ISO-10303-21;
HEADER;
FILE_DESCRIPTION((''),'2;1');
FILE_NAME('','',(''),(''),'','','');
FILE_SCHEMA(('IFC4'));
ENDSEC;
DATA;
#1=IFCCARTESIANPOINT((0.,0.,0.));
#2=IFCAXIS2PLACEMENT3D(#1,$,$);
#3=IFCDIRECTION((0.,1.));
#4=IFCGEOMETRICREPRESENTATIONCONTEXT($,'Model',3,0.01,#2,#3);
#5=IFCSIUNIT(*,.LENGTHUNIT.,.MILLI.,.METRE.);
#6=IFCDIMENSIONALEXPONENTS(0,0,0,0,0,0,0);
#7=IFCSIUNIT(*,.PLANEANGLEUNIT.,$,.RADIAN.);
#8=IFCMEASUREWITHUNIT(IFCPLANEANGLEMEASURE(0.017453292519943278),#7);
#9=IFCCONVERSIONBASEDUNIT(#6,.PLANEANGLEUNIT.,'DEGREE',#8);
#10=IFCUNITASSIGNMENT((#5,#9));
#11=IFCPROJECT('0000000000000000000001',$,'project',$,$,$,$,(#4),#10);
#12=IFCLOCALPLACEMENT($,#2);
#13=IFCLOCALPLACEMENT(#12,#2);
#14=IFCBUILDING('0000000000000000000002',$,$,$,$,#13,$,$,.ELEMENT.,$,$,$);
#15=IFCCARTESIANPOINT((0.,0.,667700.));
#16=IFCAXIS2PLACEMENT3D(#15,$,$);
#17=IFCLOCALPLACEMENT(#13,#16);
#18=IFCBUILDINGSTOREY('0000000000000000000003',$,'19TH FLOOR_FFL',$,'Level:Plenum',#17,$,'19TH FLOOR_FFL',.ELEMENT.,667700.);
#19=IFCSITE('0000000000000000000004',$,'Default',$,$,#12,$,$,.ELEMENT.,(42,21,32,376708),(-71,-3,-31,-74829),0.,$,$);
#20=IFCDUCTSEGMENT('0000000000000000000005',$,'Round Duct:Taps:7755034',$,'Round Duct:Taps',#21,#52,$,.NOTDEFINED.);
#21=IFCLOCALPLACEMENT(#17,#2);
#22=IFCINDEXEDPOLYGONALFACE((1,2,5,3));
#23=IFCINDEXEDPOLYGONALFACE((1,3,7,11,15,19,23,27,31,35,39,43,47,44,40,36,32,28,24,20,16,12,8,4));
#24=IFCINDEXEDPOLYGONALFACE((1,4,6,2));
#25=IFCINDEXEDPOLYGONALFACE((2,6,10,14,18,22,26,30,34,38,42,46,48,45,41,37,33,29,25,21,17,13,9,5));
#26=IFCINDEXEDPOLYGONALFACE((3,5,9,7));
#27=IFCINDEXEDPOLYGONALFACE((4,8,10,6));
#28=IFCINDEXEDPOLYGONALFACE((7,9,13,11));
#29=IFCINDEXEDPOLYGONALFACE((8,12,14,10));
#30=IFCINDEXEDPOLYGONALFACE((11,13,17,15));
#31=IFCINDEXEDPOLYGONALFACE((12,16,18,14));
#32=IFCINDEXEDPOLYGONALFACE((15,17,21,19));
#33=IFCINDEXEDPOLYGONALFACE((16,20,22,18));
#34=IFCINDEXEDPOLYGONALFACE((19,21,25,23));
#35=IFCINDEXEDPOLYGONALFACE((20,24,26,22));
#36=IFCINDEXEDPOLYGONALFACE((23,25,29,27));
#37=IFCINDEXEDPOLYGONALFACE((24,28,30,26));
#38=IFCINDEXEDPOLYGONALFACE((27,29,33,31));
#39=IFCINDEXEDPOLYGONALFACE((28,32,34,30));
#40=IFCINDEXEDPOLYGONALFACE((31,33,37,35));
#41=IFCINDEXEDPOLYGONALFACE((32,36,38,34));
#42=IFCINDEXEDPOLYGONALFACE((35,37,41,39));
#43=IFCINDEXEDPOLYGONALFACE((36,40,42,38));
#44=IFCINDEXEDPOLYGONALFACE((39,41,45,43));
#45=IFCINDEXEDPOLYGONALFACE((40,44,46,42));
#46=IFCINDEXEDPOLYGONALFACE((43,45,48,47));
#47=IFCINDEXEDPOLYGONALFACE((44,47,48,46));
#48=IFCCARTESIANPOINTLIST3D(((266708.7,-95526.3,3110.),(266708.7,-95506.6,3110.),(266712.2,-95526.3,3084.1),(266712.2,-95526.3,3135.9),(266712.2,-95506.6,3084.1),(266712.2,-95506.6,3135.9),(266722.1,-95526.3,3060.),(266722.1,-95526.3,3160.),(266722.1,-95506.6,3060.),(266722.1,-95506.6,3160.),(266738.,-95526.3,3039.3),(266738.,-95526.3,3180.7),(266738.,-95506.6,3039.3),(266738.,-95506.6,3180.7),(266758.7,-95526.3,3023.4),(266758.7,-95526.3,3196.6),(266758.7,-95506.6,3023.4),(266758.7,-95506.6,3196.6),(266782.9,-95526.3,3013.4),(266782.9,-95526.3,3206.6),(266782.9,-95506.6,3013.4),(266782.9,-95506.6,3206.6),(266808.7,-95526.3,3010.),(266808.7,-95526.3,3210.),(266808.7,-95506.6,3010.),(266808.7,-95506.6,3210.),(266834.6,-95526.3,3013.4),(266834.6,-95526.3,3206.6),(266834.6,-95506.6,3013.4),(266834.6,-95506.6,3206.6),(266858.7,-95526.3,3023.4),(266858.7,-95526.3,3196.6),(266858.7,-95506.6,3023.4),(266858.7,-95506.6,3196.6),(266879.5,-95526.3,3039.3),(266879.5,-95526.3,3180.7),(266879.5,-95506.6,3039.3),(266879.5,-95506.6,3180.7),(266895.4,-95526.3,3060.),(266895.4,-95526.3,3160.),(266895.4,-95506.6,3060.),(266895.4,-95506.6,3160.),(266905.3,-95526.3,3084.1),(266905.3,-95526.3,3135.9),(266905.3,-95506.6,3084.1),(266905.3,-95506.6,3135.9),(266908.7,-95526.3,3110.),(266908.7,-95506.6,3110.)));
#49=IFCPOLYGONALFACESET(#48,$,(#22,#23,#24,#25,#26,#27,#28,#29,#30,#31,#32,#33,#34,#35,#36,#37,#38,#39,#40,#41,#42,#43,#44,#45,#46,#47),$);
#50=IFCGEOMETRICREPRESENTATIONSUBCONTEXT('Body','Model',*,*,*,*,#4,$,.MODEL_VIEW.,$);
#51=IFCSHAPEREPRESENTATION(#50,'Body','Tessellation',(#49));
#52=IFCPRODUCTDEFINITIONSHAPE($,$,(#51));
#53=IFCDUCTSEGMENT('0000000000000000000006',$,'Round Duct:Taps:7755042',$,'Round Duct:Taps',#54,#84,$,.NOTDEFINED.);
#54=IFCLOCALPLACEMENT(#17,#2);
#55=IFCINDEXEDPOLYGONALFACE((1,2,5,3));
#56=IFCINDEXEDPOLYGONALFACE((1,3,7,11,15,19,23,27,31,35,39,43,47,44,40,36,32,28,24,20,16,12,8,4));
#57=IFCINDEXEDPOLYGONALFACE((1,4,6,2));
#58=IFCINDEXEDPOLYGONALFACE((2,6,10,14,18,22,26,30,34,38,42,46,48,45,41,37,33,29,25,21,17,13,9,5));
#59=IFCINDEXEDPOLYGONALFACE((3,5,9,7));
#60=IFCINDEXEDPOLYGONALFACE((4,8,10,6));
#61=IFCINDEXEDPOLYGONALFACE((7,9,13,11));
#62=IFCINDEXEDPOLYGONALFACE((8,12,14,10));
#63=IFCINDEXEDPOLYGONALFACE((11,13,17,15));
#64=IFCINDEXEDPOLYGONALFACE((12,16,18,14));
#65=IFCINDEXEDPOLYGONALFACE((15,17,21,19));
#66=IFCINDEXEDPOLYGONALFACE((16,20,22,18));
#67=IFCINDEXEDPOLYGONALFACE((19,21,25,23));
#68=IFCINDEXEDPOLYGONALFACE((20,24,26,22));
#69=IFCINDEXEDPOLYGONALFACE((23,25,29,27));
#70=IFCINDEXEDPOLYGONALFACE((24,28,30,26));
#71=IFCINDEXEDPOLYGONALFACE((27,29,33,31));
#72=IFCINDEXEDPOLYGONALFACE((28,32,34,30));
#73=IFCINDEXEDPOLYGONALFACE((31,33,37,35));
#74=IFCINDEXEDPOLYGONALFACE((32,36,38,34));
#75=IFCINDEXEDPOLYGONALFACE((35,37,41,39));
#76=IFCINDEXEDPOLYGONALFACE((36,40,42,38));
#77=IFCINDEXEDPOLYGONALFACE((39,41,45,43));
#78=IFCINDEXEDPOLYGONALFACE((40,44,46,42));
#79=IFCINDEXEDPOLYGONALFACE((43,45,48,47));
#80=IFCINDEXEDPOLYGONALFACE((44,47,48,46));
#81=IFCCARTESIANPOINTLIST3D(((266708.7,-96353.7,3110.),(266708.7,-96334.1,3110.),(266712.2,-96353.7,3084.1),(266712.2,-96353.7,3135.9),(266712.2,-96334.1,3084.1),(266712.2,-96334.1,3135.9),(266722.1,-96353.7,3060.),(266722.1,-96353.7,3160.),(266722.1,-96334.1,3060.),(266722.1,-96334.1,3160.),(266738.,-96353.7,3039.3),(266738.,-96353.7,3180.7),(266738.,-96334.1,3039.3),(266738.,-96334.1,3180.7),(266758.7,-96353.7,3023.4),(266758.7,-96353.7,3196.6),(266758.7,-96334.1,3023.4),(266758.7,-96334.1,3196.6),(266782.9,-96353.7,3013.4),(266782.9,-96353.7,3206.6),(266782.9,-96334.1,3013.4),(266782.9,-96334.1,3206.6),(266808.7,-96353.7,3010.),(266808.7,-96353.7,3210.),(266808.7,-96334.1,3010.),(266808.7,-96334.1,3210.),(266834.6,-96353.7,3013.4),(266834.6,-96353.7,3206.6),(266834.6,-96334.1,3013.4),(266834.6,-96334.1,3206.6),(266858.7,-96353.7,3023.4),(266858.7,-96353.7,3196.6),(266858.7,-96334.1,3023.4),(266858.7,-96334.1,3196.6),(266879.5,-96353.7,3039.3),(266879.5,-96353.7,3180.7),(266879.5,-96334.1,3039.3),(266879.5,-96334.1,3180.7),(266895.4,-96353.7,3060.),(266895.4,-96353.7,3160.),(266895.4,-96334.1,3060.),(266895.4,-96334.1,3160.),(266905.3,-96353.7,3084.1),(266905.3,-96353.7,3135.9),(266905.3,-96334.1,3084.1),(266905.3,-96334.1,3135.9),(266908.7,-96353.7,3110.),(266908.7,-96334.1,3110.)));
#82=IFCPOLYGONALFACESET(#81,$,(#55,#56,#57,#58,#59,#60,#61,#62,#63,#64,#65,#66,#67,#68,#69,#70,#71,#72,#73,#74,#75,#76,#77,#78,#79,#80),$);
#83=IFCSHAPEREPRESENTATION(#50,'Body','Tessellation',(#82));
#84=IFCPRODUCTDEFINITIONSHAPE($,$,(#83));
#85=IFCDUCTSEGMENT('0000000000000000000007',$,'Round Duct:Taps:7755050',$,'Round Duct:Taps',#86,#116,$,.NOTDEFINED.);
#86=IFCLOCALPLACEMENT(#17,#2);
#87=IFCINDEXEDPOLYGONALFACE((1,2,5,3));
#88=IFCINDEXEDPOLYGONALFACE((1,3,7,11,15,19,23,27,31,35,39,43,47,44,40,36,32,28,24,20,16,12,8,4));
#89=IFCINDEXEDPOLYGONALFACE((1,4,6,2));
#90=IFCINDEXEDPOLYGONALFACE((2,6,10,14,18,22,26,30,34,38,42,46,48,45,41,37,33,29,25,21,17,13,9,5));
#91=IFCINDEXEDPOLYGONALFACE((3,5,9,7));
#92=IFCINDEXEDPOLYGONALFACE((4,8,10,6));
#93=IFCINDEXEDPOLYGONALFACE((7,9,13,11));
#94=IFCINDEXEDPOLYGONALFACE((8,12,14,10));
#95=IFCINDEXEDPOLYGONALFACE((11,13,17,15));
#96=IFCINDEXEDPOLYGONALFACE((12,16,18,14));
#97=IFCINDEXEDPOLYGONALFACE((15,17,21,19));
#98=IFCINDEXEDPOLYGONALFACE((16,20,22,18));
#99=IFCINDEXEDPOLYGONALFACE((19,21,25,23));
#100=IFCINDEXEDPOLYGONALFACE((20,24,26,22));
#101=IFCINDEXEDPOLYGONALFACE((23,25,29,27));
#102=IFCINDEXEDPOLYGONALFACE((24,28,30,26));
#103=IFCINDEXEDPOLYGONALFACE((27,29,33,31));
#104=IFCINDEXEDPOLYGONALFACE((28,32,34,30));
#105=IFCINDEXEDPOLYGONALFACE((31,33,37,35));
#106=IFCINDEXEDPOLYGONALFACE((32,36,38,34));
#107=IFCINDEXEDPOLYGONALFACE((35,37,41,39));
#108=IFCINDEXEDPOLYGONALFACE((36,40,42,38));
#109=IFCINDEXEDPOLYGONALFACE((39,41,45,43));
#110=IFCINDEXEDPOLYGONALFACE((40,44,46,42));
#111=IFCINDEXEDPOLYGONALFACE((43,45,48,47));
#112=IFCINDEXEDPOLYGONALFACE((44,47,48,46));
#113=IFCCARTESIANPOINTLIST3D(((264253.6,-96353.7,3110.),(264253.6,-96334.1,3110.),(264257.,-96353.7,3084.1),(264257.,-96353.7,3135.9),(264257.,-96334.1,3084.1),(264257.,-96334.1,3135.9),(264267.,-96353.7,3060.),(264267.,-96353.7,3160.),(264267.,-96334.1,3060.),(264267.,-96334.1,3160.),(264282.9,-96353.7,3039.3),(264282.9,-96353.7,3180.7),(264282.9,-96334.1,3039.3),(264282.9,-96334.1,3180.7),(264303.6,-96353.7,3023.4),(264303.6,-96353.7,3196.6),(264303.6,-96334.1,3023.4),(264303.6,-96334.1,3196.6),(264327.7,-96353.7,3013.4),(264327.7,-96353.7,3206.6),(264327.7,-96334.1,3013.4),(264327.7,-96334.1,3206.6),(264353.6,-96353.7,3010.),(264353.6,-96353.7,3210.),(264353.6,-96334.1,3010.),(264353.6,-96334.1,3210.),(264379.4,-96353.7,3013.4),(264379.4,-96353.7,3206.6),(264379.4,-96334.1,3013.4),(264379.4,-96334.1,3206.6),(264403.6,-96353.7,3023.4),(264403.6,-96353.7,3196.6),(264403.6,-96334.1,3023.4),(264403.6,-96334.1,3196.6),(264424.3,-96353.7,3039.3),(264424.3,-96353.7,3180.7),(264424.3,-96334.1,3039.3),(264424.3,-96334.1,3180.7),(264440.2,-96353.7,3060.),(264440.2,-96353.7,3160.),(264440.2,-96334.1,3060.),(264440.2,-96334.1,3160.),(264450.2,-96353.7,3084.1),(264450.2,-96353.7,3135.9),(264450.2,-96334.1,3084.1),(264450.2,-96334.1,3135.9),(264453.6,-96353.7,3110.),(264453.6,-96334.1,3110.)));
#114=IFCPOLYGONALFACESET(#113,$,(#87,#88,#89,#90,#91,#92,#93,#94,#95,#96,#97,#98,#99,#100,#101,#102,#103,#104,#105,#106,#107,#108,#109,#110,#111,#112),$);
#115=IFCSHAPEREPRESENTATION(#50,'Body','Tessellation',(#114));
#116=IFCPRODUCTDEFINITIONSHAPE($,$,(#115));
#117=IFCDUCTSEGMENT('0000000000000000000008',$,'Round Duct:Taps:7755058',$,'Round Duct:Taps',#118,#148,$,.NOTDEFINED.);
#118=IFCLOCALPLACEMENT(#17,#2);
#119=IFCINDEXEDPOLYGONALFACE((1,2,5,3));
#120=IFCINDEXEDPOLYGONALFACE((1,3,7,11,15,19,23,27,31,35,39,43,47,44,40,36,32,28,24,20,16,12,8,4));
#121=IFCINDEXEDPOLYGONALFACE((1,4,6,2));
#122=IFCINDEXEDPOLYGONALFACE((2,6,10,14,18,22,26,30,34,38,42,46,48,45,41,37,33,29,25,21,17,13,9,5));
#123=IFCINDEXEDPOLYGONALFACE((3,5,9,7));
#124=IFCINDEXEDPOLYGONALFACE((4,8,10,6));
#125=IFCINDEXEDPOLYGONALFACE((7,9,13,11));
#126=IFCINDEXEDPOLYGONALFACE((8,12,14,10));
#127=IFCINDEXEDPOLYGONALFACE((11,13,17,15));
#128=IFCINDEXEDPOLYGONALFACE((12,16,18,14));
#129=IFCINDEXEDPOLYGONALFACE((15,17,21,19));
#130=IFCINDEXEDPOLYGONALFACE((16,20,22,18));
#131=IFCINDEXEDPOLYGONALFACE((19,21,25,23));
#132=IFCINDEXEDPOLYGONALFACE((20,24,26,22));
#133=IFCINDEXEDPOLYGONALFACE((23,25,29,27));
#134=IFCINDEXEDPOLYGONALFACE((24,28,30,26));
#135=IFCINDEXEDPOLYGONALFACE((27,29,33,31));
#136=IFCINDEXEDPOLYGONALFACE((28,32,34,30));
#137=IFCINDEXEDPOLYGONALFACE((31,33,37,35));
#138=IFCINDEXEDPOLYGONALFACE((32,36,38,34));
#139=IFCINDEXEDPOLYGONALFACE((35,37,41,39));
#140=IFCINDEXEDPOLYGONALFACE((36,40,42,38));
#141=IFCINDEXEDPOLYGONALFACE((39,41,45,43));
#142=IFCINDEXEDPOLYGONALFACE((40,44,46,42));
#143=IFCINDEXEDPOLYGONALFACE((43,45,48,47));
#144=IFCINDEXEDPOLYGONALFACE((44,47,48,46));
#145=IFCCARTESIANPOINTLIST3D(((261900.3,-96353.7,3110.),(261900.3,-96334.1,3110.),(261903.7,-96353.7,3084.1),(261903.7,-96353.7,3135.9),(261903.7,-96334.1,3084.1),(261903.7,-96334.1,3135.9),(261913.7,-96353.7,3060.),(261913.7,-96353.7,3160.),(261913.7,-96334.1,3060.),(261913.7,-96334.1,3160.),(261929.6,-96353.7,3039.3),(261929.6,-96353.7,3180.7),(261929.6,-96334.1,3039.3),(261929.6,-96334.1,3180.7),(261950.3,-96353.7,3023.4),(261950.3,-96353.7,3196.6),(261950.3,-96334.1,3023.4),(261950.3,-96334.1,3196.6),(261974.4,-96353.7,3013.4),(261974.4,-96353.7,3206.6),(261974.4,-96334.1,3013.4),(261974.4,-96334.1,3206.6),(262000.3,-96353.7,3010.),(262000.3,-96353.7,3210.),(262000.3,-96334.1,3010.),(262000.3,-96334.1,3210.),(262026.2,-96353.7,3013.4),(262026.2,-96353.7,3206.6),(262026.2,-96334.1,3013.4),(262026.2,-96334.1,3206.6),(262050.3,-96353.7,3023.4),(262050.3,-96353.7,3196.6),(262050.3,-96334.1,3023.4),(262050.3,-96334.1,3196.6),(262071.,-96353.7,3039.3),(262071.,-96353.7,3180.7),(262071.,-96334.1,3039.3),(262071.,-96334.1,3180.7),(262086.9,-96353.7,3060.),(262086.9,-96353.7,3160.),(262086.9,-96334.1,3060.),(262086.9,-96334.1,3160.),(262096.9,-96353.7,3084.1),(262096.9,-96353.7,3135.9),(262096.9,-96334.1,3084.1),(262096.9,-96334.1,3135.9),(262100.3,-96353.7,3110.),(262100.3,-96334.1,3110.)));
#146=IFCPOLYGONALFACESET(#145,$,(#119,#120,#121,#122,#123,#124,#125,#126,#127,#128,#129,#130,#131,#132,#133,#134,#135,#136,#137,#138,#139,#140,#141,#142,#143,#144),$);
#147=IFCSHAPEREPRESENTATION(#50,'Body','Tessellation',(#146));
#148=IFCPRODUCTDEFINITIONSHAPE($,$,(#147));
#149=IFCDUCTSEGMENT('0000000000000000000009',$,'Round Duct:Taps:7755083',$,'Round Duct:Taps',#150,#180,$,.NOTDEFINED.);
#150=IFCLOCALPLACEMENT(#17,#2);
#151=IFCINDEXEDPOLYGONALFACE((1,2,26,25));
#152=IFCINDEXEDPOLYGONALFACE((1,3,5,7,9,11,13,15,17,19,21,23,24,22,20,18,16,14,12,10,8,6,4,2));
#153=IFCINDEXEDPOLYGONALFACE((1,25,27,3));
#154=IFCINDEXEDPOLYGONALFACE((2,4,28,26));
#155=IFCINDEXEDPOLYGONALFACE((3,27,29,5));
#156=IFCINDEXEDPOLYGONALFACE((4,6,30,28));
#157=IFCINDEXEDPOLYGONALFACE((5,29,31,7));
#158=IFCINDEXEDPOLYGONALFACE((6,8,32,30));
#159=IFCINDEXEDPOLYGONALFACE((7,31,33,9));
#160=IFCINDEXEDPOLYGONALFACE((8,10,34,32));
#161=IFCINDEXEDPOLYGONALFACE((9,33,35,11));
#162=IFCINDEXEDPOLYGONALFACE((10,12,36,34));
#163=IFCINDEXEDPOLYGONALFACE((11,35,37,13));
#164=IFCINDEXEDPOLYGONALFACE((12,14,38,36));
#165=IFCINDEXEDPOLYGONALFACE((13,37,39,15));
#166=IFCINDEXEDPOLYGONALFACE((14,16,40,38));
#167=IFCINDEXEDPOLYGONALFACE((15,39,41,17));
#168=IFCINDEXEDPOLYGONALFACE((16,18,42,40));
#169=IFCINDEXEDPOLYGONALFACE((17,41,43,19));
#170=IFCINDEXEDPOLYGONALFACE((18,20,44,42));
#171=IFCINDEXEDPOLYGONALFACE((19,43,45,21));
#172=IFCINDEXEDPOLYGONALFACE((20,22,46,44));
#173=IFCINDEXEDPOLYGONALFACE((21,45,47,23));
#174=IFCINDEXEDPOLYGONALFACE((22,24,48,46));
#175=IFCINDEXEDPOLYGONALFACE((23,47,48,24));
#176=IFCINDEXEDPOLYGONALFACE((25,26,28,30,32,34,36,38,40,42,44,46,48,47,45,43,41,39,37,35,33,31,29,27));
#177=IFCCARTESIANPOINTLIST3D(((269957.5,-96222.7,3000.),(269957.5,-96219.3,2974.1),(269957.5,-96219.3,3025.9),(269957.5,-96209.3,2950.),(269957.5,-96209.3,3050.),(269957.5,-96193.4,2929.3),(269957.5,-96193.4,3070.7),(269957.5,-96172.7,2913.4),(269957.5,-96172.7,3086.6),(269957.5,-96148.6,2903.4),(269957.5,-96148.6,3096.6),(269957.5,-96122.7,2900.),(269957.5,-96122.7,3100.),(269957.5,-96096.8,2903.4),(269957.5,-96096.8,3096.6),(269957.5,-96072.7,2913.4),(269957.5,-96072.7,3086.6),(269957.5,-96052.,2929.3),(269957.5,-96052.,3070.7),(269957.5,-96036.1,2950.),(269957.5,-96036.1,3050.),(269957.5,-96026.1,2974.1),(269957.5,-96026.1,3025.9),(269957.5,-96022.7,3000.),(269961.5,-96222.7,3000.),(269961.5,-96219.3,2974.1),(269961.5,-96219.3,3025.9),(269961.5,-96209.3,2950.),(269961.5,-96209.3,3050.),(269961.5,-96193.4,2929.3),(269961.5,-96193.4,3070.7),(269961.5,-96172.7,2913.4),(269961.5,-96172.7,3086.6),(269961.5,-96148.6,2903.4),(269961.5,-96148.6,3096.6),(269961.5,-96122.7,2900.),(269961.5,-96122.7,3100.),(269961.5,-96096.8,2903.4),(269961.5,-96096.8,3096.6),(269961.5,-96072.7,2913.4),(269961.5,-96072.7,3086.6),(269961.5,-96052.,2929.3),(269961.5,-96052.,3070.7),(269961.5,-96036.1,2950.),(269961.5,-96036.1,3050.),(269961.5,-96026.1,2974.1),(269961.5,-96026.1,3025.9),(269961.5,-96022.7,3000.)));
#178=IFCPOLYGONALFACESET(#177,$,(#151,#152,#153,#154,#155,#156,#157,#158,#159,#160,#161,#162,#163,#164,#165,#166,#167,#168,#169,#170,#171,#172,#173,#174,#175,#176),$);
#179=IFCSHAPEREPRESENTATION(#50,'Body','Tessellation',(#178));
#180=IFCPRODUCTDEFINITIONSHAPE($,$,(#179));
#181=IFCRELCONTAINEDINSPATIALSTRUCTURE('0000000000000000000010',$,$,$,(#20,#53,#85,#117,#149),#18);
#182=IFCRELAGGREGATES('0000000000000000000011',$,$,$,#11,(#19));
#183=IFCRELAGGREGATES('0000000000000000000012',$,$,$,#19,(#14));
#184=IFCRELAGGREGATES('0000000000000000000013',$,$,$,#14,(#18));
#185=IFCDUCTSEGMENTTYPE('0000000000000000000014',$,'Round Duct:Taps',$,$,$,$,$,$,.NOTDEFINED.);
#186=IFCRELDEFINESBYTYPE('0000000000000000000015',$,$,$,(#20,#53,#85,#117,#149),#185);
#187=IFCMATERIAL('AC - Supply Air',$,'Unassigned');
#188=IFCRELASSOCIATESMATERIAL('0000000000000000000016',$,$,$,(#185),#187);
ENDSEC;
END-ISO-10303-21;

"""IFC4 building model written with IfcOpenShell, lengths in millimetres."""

from ifc_helpers import new_model, entity, si_unit, converted_unit, direction, frame, origin, place, context, subcontext, project, spatial, arc, indexed_curve, outline, extrude, material, type_object, element, save


model = new_model("IFC4")

# Units and contexts
model_context = context("Model", 3, precision=0.01, world=origin(), true_north=direction((0.0, 1.0)))
body_context = subcontext(model_context, "Body", "Model", "MODEL_VIEW")
ifc_project = project(units=[si_unit("LENGTHUNIT", "METRE", prefix="MILLI"), converted_unit("PLANEANGLEUNIT", "DEGREE", entity("IfcPlaneAngleMeasure", 0.017453292519943278), si_unit("PLANEANGLEUNIT", "RADIAN"), dimensions=[0, 0, 0, 0, 0, 0, 0])], contexts=[model_context])

# Site, building, storey
site_placement = place(None, origin())
site = spatial("IfcSite", under=ifc_project, at=site_placement, Name="Default", CompositionType="ELEMENT", RefLatitude=(42, 21, 32, 376708), RefLongitude=(-71, -3, -31, -74829), RefElevation=0.0)
building_placement = place(site_placement, origin())
building = spatial("IfcBuilding", under=site, at=building_placement, CompositionType="ELEMENT")
storey_placement = place(building_placement, frame((0.0, 0.0, 667700.0)))
storey = spatial("IfcBuildingStorey", under=building, at=storey_placement, Name="19TH FLOOR_FFL", ObjectType="Level:Plenum", LongName="19TH FLOOR_FFL", CompositionType="ELEMENT", Elevation=667700.0)

# Duct segments
ifc_material_1 = material(Name="AC - Supply Air", Category="Unassigned")
duct_segment_type_1 = type_object("IfcDuctSegmentType", Name="Round Duct:Taps", PredefinedType="NOTDEFINED", material=ifc_material_1)
duct_segment_1_placement = place(storey_placement, origin())
element("IfcDuctSegment", 1, at=duct_segment_1_placement, inside=storey, type_object=duct_segment_type_1, Name="Round Duct:Taps:7755034", ObjectType="Round Duct:Taps", PredefinedType="NOTDEFINED", context=body_context, shape_type="SweptSolid", body=[
    extrude(outline(indexed_curve([(100.0, 0.0), (70.7, 70.7), (0.0, 100.0), (-70.7, 70.7), (-100.0, 0.0), (-70.7, -70.7), (0.0, -100.0), (70.7, -70.7)], segments=[arc(1, 2, 3), arc(3, 4, 5), arc(5, 6, 7), arc(7, 8, 1)], self_intersect=False)), frame((266808.7, -95526.3, 3110.0), z_axis=(0.0, 1.0, 0.0), x_axis=(1.0, 0.0, 0.0)), (0.0, 0.0, 1.0), 19.6),
])
duct_segment_2_placement = place(storey_placement, origin())
element("IfcDuctSegment", 2, at=duct_segment_2_placement, inside=storey, type_object=duct_segment_type_1, Name="Round Duct:Taps:7755042", ObjectType="Round Duct:Taps", PredefinedType="NOTDEFINED", context=body_context, shape_type="SweptSolid", body=[
    extrude(outline(indexed_curve([(100.0, 0.0), (70.7, 70.7), (0.0, 100.0), (-70.7, 70.7), (-100.0, 0.0), (-70.7, -70.7), (0.0, -100.0), (70.7, -70.7)], segments=[arc(1, 2, 3), arc(3, 4, 5), arc(5, 6, 7), arc(7, 8, 1)], self_intersect=False)), frame((266808.7, -96353.7, 3110.0), z_axis=(0.0, 1.0, 0.0), x_axis=(-1.0, 0.0, 0.0)), (0.0, 0.0, 1.0), 19.6),
])
duct_segment_3_placement = place(storey_placement, origin())
element("IfcDuctSegment", 3, at=duct_segment_3_placement, inside=storey, type_object=duct_segment_type_1, Name="Round Duct:Taps:7755050", ObjectType="Round Duct:Taps", PredefinedType="NOTDEFINED", context=body_context, shape_type="SweptSolid", body=[
    extrude(outline(indexed_curve([(100.0, 0.0), (70.7, 70.7), (0.0, 100.0), (-70.7, 70.7), (-100.0, 0.0), (-70.7, -70.7), (0.0, -100.0), (70.7, -70.7)], segments=[arc(1, 2, 3), arc(3, 4, 5), arc(5, 6, 7), arc(7, 8, 1)], self_intersect=False)), frame((264353.6, -96353.7, 3110.0), z_axis=(0.0, 1.0, 0.0), x_axis=(-1.0, 0.0, 0.0)), (0.0, 0.0, 1.0), 19.6),
])
duct_segment_4_placement = place(storey_placement, origin())
element("IfcDuctSegment", 4, at=duct_segment_4_placement, inside=storey, type_object=duct_segment_type_1, Name="Round Duct:Taps:7755058", ObjectType="Round Duct:Taps", PredefinedType="NOTDEFINED", context=body_context, shape_type="SweptSolid", body=[
    extrude(outline(indexed_curve([(100.0, 0.0), (70.7, 70.7), (0.0, 100.0), (-70.7, 70.7), (-100.0, 0.0), (-70.7, -70.7), (0.0, -100.0), (70.7, -70.7)], segments=[arc(1, 2, 3), arc(3, 4, 5), arc(5, 6, 7), arc(7, 8, 1)], self_intersect=False)), frame((262000.3, -96353.7, 3110.0), z_axis=(0.0, 1.0, 0.0), x_axis=(-1.0, 0.0, 0.0)), (0.0, 0.0, 1.0), 19.6),
])
duct_segment_5_placement = place(storey_placement, origin())
element("IfcDuctSegment", 5, at=duct_segment_5_placement, inside=storey, type_object=duct_segment_type_1, Name="Round Duct:Taps:7755083", ObjectType="Round Duct:Taps", PredefinedType="NOTDEFINED", context=body_context, shape_type="SweptSolid", body=[
    extrude(outline(indexed_curve([(100.0, 0.0), (70.7, 70.7), (0.0, 100.0), (-70.7, 70.7), (-100.0, 0.0), (-70.7, -70.7), (0.0, -100.0), (70.7, -70.7)], segments=[arc(1, 2, 3), arc(3, 4, 5), arc(5, 6, 7), arc(7, 8, 1)], self_intersect=False)), frame((269957.5, -96122.7, 3000.0), z_axis=(1.0, 0.0, 0.0), x_axis=(0.0, 1.0, 0.0)), (0.0, 0.0, 1.0), 3.9),
])

save(model, "model.ifc")
